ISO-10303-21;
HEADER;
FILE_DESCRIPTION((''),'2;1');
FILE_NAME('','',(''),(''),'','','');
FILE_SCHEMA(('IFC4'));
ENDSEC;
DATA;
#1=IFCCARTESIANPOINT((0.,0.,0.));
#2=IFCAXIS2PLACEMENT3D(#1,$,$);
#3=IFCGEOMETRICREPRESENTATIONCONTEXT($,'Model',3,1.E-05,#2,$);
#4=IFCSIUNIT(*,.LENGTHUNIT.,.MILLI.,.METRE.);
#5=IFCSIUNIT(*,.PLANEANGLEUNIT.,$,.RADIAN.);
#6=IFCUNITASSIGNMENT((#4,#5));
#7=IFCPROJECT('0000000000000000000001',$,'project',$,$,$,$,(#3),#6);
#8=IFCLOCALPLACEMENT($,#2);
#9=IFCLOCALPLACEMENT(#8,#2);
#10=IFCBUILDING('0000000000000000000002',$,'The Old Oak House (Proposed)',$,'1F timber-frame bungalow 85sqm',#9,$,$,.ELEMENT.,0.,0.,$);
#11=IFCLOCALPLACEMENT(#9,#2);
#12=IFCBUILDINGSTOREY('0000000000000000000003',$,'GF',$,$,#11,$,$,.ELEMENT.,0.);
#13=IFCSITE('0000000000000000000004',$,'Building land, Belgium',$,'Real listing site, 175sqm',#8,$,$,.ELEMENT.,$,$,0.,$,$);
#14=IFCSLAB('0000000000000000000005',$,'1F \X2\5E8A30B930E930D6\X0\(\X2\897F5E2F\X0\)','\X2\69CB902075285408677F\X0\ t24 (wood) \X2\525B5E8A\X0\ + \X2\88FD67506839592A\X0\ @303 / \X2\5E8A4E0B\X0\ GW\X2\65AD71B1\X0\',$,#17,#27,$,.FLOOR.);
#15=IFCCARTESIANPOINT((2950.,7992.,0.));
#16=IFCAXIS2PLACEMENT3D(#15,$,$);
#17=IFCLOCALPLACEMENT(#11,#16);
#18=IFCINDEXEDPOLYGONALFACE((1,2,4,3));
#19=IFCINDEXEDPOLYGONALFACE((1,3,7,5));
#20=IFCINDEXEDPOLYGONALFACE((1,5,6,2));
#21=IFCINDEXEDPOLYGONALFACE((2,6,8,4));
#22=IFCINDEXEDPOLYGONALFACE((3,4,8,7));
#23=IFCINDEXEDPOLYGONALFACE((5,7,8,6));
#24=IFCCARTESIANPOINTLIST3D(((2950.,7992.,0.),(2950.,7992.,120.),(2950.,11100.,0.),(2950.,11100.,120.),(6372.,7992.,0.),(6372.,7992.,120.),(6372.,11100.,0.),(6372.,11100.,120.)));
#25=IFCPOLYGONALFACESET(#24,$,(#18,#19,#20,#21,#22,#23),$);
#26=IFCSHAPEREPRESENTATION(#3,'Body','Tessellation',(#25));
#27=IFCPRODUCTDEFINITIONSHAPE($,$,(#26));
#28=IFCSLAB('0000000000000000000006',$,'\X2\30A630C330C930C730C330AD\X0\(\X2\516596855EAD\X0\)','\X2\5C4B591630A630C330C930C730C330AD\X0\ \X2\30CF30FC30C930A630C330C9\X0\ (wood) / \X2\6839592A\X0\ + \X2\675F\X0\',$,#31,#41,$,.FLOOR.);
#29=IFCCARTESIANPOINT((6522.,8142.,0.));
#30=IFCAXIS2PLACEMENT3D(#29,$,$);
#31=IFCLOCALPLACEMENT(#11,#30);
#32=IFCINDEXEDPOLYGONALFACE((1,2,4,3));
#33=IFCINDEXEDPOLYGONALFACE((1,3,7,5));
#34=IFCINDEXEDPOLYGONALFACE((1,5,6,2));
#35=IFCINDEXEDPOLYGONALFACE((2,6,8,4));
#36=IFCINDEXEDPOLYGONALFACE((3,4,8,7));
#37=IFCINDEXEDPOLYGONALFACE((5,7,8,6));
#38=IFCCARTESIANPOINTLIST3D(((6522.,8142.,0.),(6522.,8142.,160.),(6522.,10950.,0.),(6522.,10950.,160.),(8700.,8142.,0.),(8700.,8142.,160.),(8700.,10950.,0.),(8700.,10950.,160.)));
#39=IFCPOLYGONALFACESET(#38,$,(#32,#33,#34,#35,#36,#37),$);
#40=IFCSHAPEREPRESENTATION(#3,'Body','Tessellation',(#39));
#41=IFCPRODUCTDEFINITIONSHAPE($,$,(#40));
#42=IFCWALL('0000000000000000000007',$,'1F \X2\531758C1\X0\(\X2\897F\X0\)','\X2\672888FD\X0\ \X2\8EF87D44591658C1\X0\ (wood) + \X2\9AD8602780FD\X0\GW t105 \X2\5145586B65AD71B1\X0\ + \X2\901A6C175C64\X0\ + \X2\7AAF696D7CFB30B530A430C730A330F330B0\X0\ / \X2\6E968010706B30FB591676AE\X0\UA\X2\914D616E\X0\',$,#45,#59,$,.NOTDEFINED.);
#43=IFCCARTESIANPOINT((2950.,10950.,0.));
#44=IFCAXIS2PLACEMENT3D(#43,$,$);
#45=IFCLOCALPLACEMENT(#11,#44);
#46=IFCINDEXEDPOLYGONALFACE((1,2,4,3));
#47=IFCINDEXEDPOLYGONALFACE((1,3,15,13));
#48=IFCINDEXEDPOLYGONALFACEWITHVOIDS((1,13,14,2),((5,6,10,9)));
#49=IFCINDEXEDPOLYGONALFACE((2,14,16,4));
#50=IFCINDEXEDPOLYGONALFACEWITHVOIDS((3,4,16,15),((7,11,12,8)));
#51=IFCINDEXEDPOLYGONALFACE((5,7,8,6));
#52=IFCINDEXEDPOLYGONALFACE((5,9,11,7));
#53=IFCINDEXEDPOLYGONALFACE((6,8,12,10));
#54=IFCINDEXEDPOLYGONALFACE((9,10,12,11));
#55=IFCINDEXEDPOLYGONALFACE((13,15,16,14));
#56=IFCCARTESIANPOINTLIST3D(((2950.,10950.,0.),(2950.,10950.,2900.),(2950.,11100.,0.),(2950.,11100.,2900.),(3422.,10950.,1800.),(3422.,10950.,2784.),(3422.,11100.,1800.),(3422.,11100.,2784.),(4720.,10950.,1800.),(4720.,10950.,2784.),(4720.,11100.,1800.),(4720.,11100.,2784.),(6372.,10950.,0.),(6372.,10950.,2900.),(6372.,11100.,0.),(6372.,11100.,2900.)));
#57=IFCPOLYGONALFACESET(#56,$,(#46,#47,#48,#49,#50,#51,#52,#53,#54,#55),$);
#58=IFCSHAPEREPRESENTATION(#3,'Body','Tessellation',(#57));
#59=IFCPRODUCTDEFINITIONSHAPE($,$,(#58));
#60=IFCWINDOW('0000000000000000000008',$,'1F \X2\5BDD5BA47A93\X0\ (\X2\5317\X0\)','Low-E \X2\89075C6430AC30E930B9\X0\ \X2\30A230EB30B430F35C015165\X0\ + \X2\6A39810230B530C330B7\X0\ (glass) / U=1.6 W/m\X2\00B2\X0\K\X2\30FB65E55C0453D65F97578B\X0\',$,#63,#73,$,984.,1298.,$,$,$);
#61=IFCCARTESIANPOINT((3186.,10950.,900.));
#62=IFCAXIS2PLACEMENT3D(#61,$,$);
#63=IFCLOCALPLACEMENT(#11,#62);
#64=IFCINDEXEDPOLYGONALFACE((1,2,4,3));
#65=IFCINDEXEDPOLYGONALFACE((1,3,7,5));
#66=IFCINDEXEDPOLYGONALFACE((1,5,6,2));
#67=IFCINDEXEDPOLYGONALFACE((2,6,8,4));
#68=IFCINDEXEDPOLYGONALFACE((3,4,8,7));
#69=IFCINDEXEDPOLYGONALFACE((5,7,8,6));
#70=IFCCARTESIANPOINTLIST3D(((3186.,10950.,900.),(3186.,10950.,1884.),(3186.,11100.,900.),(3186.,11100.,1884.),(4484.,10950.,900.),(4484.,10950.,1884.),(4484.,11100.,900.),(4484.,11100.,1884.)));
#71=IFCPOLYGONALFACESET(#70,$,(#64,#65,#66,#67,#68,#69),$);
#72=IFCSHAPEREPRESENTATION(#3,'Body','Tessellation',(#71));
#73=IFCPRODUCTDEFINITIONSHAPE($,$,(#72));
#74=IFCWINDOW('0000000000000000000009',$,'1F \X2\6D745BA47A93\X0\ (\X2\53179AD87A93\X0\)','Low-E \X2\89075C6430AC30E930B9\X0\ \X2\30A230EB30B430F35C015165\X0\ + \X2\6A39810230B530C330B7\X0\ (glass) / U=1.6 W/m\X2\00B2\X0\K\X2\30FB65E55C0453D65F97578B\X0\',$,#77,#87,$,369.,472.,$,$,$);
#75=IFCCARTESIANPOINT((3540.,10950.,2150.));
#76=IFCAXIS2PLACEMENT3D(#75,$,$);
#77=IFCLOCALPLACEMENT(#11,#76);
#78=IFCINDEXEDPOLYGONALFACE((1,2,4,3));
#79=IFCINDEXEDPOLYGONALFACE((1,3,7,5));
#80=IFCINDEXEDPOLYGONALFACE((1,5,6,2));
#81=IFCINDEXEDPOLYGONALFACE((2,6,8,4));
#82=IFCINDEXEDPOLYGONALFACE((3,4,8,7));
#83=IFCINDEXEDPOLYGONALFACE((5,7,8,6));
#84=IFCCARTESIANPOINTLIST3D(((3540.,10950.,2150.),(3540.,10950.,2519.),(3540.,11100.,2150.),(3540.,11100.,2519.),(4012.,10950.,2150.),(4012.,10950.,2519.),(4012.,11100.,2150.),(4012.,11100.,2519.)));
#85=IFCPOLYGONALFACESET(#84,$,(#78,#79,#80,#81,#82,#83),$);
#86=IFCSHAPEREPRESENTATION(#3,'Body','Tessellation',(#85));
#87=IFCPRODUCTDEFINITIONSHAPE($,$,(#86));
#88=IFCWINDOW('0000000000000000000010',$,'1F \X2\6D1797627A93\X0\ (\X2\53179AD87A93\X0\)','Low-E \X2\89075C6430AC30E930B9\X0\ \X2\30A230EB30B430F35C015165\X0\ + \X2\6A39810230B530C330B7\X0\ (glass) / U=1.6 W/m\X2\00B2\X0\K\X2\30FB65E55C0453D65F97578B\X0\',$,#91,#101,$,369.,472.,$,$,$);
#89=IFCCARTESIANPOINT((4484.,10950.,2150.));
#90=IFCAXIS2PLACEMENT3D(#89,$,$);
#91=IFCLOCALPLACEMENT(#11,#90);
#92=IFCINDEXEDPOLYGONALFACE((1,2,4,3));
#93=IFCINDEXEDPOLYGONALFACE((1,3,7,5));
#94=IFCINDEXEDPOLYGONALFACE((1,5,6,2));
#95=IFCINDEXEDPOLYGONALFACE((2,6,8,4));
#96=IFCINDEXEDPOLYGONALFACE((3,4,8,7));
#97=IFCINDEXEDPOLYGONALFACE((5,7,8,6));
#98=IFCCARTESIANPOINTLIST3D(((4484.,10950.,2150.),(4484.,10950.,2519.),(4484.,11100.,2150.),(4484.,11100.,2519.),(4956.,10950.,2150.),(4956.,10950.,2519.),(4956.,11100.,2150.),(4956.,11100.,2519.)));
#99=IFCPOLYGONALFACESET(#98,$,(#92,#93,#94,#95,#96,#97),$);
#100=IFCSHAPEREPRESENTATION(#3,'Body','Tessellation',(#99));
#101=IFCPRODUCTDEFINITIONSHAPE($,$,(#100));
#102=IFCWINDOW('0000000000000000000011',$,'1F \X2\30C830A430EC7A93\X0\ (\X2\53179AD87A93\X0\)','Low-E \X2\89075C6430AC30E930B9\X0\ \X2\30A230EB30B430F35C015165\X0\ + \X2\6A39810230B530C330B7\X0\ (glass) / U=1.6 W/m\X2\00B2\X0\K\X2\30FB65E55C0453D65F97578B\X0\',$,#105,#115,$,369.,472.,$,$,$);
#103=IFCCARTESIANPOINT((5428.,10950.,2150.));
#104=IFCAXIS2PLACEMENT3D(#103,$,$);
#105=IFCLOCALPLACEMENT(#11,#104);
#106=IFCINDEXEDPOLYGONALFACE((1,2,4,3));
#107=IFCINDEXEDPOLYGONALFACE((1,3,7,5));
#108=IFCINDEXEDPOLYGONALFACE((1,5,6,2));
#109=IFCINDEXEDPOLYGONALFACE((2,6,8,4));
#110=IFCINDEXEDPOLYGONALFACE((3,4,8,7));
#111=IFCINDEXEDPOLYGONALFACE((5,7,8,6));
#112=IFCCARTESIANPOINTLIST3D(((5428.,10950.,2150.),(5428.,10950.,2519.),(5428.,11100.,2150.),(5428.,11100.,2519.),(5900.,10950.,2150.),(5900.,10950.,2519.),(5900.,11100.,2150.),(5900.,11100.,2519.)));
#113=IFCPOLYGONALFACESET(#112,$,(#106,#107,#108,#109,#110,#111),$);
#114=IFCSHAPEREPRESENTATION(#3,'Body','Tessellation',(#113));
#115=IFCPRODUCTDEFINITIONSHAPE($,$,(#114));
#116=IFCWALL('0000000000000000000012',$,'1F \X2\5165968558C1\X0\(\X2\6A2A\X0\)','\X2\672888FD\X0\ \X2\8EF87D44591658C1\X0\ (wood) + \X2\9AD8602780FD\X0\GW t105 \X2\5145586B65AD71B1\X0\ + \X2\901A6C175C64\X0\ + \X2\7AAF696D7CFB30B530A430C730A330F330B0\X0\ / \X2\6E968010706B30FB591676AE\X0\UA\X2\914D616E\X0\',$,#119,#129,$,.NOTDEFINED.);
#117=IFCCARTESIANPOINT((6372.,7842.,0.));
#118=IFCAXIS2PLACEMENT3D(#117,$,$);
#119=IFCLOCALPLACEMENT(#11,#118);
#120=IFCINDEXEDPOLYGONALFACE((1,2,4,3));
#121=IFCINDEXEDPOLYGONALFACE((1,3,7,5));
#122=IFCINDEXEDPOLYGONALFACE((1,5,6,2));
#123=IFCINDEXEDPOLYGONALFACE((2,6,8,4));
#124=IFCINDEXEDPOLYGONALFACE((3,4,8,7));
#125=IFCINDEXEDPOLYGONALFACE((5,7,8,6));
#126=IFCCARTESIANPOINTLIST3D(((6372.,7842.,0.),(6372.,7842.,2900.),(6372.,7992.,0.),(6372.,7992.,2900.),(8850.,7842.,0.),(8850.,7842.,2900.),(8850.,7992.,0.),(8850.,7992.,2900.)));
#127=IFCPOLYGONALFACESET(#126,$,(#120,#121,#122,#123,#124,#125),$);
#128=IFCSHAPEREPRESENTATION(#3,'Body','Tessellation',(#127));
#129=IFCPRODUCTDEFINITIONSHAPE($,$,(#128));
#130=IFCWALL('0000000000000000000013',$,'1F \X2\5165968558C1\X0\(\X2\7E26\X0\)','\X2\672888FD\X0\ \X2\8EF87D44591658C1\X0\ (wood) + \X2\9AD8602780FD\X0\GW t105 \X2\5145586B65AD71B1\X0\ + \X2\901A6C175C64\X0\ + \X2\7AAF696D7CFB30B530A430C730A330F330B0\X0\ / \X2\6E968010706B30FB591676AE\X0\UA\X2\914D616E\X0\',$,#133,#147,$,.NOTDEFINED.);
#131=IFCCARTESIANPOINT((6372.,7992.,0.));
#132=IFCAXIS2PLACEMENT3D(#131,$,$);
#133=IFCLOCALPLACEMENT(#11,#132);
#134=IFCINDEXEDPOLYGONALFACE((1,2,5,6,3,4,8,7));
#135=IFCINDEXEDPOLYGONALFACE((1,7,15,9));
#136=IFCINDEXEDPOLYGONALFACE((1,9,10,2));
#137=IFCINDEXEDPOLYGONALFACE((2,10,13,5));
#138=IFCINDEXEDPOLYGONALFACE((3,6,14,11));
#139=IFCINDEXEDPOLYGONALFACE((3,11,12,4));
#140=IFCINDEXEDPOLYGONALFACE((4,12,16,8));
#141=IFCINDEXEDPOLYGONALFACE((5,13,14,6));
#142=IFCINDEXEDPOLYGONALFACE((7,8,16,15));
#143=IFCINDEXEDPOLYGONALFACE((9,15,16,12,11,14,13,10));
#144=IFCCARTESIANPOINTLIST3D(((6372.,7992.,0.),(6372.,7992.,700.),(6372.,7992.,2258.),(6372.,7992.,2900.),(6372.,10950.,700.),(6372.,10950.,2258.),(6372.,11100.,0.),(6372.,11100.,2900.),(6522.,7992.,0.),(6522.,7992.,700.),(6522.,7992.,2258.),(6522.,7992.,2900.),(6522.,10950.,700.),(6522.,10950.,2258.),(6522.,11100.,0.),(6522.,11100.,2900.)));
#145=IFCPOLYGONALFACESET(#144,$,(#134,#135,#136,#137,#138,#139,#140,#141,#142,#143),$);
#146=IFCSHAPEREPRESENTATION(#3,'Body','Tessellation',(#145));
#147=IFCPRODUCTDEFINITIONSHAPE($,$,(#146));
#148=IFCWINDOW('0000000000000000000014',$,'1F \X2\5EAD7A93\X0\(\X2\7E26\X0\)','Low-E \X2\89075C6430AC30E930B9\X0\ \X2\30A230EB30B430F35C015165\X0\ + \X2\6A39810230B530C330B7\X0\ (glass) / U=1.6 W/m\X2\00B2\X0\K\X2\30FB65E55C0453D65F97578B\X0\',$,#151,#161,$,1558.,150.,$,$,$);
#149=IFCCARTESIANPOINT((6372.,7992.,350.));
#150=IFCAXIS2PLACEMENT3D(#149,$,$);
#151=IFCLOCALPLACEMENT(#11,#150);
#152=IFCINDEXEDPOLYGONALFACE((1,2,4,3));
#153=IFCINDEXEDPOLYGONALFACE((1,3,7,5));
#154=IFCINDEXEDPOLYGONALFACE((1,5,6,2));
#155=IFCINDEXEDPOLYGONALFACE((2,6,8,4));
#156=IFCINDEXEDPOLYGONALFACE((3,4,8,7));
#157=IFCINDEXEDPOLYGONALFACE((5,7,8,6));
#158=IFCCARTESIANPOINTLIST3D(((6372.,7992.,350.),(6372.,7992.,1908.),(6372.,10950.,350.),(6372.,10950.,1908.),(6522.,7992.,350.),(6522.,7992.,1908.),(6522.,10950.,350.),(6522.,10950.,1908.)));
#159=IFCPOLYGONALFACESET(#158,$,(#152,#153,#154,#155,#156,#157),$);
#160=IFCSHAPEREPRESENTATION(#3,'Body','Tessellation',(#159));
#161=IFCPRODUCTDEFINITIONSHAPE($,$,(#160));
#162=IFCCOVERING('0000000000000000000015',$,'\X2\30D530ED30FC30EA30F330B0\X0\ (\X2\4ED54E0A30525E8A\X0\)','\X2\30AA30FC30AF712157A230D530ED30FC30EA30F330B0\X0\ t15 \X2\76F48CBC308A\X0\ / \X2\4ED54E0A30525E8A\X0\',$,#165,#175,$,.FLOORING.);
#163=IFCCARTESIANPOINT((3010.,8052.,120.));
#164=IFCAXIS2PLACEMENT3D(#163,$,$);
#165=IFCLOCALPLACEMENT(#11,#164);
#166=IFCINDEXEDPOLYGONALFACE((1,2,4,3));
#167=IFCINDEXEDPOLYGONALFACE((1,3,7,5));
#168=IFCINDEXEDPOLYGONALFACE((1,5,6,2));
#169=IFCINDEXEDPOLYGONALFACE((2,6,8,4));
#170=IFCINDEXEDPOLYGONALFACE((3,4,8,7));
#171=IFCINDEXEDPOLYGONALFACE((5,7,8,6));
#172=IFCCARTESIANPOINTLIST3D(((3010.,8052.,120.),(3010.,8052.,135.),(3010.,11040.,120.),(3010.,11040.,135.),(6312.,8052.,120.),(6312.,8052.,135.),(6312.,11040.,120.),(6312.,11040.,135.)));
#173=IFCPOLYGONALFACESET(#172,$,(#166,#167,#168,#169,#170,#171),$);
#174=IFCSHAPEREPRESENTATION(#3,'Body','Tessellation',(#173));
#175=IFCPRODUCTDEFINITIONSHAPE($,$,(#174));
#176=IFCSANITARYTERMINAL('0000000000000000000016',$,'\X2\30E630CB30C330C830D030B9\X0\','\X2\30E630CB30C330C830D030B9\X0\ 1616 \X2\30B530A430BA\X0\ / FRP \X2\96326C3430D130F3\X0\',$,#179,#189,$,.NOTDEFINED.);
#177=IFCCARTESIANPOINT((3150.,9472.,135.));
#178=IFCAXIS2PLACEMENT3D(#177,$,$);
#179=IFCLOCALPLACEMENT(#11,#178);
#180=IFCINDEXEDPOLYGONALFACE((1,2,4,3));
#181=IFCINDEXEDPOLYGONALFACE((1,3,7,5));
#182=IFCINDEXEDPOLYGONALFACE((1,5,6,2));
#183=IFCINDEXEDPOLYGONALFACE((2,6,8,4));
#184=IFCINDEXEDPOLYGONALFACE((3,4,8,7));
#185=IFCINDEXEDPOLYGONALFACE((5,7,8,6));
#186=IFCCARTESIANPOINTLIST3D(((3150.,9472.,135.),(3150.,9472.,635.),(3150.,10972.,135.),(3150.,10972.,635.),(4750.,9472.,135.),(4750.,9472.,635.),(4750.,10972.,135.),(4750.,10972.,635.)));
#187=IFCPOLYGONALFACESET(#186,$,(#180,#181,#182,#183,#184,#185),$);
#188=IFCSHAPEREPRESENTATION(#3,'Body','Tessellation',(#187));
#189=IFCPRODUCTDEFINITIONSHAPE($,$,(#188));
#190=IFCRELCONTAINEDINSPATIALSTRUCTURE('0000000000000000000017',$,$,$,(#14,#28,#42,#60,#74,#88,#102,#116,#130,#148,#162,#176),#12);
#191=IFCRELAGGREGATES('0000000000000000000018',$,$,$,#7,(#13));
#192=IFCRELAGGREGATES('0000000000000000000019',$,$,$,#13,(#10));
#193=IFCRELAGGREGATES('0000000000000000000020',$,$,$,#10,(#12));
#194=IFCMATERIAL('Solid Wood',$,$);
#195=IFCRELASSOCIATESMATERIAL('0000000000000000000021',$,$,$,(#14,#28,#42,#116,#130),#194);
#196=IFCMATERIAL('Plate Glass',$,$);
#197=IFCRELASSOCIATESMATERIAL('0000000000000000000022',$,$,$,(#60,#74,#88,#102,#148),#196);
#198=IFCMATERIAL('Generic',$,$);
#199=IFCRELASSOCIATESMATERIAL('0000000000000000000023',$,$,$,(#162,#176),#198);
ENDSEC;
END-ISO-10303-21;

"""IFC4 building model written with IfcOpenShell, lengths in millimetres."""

from ifc_helpers import new_model, si_unit, frame, frame_2d, origin, place, context, project, spatial, rectangle, extrude, material, element, fill, save


model = new_model("IFC4")

# Units and contexts
model_context = context("Model", 3, precision=1e-05, world=origin())
ifc_project = project(units=[si_unit("LENGTHUNIT", "METRE", prefix="MILLI"), si_unit("PLANEANGLEUNIT", "RADIAN")], contexts=[model_context])

# Site, building, storey
site_placement = place(None, origin())
site = spatial("IfcSite", under=ifc_project, at=site_placement, Name="Building land, Belgium", ObjectType="Real listing site, 175sqm", CompositionType="ELEMENT", RefElevation=0.0)
building_placement = place(site_placement, origin())
building = spatial("IfcBuilding", under=site, at=building_placement, Name="The Old Oak House (Proposed)", ObjectType="1F timber-frame bungalow 85sqm", CompositionType="ELEMENT", ElevationOfRefHeight=0.0, ElevationOfTerrain=0.0)
storey_placement = place(building_placement, origin())
storey = spatial("IfcBuildingStorey", under=building, at=storey_placement, Name="GF", CompositionType="ELEMENT", Elevation=0.0)

# Slabs
ifc_material_1 = material(Name="Solid Wood")
slab_1_placement = place(storey_placement, frame((2950.0, 7992.0, 0.0)))
element("IfcSlab", 1, at=slab_1_placement, inside=storey, material=ifc_material_1, Name="1F 床スラブ(西帯)", Description="構造用合板 t24 (wood) 剛床 + 製材根太 @303 / 床下 GW断熱", PredefinedType="FLOOR", context=model_context, shape_type="SweptSolid", body=[
    extrude(rectangle(XDim=3422.0, YDim=3108.0, at=frame_2d((1711.0, 1554.0))), frame((2950.0, 7992.0, 0.0)), (0.0, 0.0, 1.0), 120.0),
])
slab_2_placement = place(storey_placement, frame((6522.0, 8142.0, 0.0)))
element("IfcSlab", 2, at=slab_2_placement, inside=storey, material=ifc_material_1, Name="ウッドデッキ(入隅庭)", Description="屋外ウッドデッキ ハードウッド (wood) / 根太 + 束", PredefinedType="FLOOR", context=model_context, shape_type="SweptSolid", body=[
    extrude(rectangle(XDim=2178.0, YDim=2808.0, at=frame_2d((1089.0, 1404.0))), frame((6522.0, 8142.0, 0.0)), (0.0, 0.0, 1.0), 160.0),
])

# Wall, openings, windows
wall_1_placement = place(storey_placement, frame((2950.0, 10950.0, 0.0)))
wall_1 = element("IfcWall", 3, at=wall_1_placement, inside=storey, material=ifc_material_1, Name="1F 北壁(西)", Description="木製 軸組外壁 (wood) + 高性能GW t105 充填断熱 + 通気層 + 窯業系サイディング / 準耐火・外皮UA配慮", PredefinedType="NOTDEFINED", context=model_context, shape_type="SweptSolid", body=[
    extrude(rectangle(XDim=3422.0, YDim=150.0, at=frame_2d((1711.0, 75.0))), frame((2950.0, 10950.0, 0.0)), (0.0, 0.0, 1.0), 2900.0),
])
opening_1_placement = place(storey_placement, frame((3186.0, 10950.0, 900.0)))
opening_1 = element("IfcOpeningElement", 4, at=opening_1_placement, cuts=wall_1, PredefinedType="NOTDEFINED", context=model_context, shape_type="SweptSolid", body=[
    extrude(rectangle(XDim=1298.0, YDim=150.0, at=frame_2d((649.0, 75.0))), frame((3186.0, 10950.0, 900.0)), (0.0, 0.0, 1.0), 984.0),
])
opening_2_placement = place(storey_placement, frame((3540.0, 10950.0, 2150.0)))
opening_2 = element("IfcOpeningElement", 5, at=opening_2_placement, cuts=wall_1, PredefinedType="NOTDEFINED", context=model_context, shape_type="SweptSolid", body=[
    extrude(rectangle(XDim=472.0, YDim=150.0, at=frame_2d((236.0, 75.0))), frame((3540.0, 10950.0, 2150.0)), (0.0, 0.0, 1.0), 369.0),
])
opening_3_placement = place(storey_placement, frame((4484.0, 10950.0, 2150.0)))
opening_3 = element("IfcOpeningElement", 6, at=opening_3_placement, cuts=wall_1, PredefinedType="NOTDEFINED", context=model_context, shape_type="SweptSolid", body=[
    extrude(rectangle(XDim=472.0, YDim=150.0, at=frame_2d((236.0, 75.0))), frame((4484.0, 10950.0, 2150.0)), (0.0, 0.0, 1.0), 369.0),
])
opening_4_placement = place(storey_placement, frame((5428.0, 10950.0, 2150.0)))
opening_4 = element("IfcOpeningElement", 7, at=opening_4_placement, cuts=wall_1, PredefinedType="NOTDEFINED", context=model_context, shape_type="SweptSolid", body=[
    extrude(rectangle(XDim=472.0, YDim=150.0, at=frame_2d((236.0, 75.0))), frame((5428.0, 10950.0, 2150.0)), (0.0, 0.0, 1.0), 369.0),
])
ifc_material_2 = material(Name="Plate Glass")
window_1_placement = place(storey_placement, frame((3186.0, 10950.0, 900.0)))
window_1 = element("IfcWindow", 8, at=window_1_placement, inside=storey, material=ifc_material_2, Name="1F 寝室窓 (北)", Description="Low-E 複層ガラス アルゴン封入 + 樹脂サッシ (glass) / U=1.6 W/m²K・日射取得型", OverallHeight=984.0, OverallWidth=1298.0, context=model_context, shape_type="SweptSolid", body=[
    extrude(rectangle(XDim=1298.0, YDim=150.0, at=frame_2d((649.0, 75.0))), frame((3186.0, 10950.0, 900.0)), (0.0, 0.0, 1.0), 984.0),
])
fill(opening_1, window_1)
window_2_placement = place(storey_placement, frame((3540.0, 10950.0, 2150.0)))
window_2 = element("IfcWindow", 9, at=window_2_placement, inside=storey, material=ifc_material_2, Name="1F 浴室窓 (北高窓)", Description="Low-E 複層ガラス アルゴン封入 + 樹脂サッシ (glass) / U=1.6 W/m²K・日射取得型", OverallHeight=369.0, OverallWidth=472.0, context=model_context, shape_type="SweptSolid", body=[
    extrude(rectangle(XDim=472.0, YDim=150.0, at=frame_2d((236.0, 75.0))), frame((3540.0, 10950.0, 2150.0)), (0.0, 0.0, 1.0), 369.0),
])
fill(opening_2, window_2)
window_3_placement = place(storey_placement, frame((4484.0, 10950.0, 2150.0)))
window_3 = element("IfcWindow", 10, at=window_3_placement, inside=storey, material=ifc_material_2, Name="1F 洗面窓 (北高窓)", Description="Low-E 複層ガラス アルゴン封入 + 樹脂サッシ (glass) / U=1.6 W/m²K・日射取得型", OverallHeight=369.0, OverallWidth=472.0, context=model_context, shape_type="SweptSolid", body=[
    extrude(rectangle(XDim=472.0, YDim=150.0, at=frame_2d((236.0, 75.0))), frame((4484.0, 10950.0, 2150.0)), (0.0, 0.0, 1.0), 369.0),
])
fill(opening_3, window_3)
window_4_placement = place(storey_placement, frame((5428.0, 10950.0, 2150.0)))
window_4 = element("IfcWindow", 11, at=window_4_placement, inside=storey, material=ifc_material_2, Name="1F トイレ窓 (北高窓)", Description="Low-E 複層ガラス アルゴン封入 + 樹脂サッシ (glass) / U=1.6 W/m²K・日射取得型", OverallHeight=369.0, OverallWidth=472.0, context=model_context, shape_type="SweptSolid", body=[
    extrude(rectangle(XDim=472.0, YDim=150.0, at=frame_2d((236.0, 75.0))), frame((5428.0, 10950.0, 2150.0)), (0.0, 0.0, 1.0), 369.0),
])
fill(opening_4, window_4)

# Wall
wall_2_placement = place(storey_placement, frame((6372.0, 7842.0, 0.0)))
element("IfcWall", 12, at=wall_2_placement, inside=storey, material=ifc_material_1, Name="1F 入隅壁(横)", Description="木製 軸組外壁 (wood) + 高性能GW t105 充填断熱 + 通気層 + 窯業系サイディング / 準耐火・外皮UA配慮", PredefinedType="NOTDEFINED", context=model_context, shape_type="SweptSolid", body=[
    extrude(rectangle(XDim=2478.0, YDim=150.0, at=frame_2d((1239.0, 75.0))), frame((6372.0, 7842.0, 0.0)), (0.0, 0.0, 1.0), 2900.0),
])

# Wall, opening, window
wall_3_placement = place(storey_placement, frame((6372.0, 7992.0, 0.0)))
wall_3 = element("IfcWall", 13, at=wall_3_placement, inside=storey, material=ifc_material_1, Name="1F 入隅壁(縦)", Description="木製 軸組外壁 (wood) + 高性能GW t105 充填断熱 + 通気層 + 窯業系サイディング / 準耐火・外皮UA配慮", PredefinedType="NOTDEFINED", context=model_context, shape_type="SweptSolid", body=[
    extrude(rectangle(XDim=150.0, YDim=3108.0, at=frame_2d((75.0, 1554.0))), frame((6372.0, 7992.0, 0.0)), (0.0, 0.0, 1.0), 2900.0),
])
opening_5_placement = place(storey_placement, frame((6372.0, 7992.0, 350.0)))
opening_5 = element("IfcOpeningElement", 14, at=opening_5_placement, cuts=wall_3, PredefinedType="NOTDEFINED", context=model_context, shape_type="SweptSolid", body=[
    extrude(rectangle(XDim=150.0, YDim=2958.0, at=frame_2d((75.0, 1479.0))), frame((6372.0, 7992.0, 350.0)), (0.0, 0.0, 1.0), 1558.0),
])
window_5_placement = place(storey_placement, frame((6372.0, 7992.0, 350.0)))
window_5 = element("IfcWindow", 15, at=window_5_placement, inside=storey, material=ifc_material_2, Name="1F 庭窓(縦)", Description="Low-E 複層ガラス アルゴン封入 + 樹脂サッシ (glass) / U=1.6 W/m²K・日射取得型", OverallHeight=1558.0, OverallWidth=150.0, context=model_context, shape_type="SweptSolid", body=[
    extrude(rectangle(XDim=150.0, YDim=2958.0, at=frame_2d((75.0, 1479.0))), frame((6372.0, 7992.0, 350.0)), (0.0, 0.0, 1.0), 1558.0),
])
fill(opening_5, window_5)

# Covering
ifc_material_3 = material(Name="Generic")
covering_placement = place(storey_placement, frame((3010.0, 8052.0, 120.0)))
element("IfcCovering", 16, at=covering_placement, inside=storey, material=ifc_material_3, Name="フローリング (仕上げ床)", Description="オーク無垢フローリング t15 直貼り / 仕上げ床", PredefinedType="FLOORING", context=model_context, shape_type="SweptSolid", body=[
    extrude(rectangle(XDim=3302.0, YDim=2988.0, at=frame_2d((1651.0, 1494.0))), frame((3010.0, 8052.0, 120.0)), (0.0, 0.0, 1.0), 15.0),
])

# Sanitary terminal
sanitary_terminal_1_placement = place(storey_placement, frame((3150.0, 9472.0, 135.0)))
element("IfcSanitaryTerminal", 17, at=sanitary_terminal_1_placement, inside=storey, material=ifc_material_3, Name="ユニットバス", Description="ユニットバス 1616 サイズ / FRP 防水パン", PredefinedType="NOTDEFINED", context=model_context, shape_type="SweptSolid", body=[
    extrude(rectangle(XDim=1600.0, YDim=1500.0, at=frame_2d((800.0, 750.0))), frame((3150.0, 9472.0, 135.0)), (0.0, 0.0, 1.0), 500.0),
])

save(model, "model.ifc")
